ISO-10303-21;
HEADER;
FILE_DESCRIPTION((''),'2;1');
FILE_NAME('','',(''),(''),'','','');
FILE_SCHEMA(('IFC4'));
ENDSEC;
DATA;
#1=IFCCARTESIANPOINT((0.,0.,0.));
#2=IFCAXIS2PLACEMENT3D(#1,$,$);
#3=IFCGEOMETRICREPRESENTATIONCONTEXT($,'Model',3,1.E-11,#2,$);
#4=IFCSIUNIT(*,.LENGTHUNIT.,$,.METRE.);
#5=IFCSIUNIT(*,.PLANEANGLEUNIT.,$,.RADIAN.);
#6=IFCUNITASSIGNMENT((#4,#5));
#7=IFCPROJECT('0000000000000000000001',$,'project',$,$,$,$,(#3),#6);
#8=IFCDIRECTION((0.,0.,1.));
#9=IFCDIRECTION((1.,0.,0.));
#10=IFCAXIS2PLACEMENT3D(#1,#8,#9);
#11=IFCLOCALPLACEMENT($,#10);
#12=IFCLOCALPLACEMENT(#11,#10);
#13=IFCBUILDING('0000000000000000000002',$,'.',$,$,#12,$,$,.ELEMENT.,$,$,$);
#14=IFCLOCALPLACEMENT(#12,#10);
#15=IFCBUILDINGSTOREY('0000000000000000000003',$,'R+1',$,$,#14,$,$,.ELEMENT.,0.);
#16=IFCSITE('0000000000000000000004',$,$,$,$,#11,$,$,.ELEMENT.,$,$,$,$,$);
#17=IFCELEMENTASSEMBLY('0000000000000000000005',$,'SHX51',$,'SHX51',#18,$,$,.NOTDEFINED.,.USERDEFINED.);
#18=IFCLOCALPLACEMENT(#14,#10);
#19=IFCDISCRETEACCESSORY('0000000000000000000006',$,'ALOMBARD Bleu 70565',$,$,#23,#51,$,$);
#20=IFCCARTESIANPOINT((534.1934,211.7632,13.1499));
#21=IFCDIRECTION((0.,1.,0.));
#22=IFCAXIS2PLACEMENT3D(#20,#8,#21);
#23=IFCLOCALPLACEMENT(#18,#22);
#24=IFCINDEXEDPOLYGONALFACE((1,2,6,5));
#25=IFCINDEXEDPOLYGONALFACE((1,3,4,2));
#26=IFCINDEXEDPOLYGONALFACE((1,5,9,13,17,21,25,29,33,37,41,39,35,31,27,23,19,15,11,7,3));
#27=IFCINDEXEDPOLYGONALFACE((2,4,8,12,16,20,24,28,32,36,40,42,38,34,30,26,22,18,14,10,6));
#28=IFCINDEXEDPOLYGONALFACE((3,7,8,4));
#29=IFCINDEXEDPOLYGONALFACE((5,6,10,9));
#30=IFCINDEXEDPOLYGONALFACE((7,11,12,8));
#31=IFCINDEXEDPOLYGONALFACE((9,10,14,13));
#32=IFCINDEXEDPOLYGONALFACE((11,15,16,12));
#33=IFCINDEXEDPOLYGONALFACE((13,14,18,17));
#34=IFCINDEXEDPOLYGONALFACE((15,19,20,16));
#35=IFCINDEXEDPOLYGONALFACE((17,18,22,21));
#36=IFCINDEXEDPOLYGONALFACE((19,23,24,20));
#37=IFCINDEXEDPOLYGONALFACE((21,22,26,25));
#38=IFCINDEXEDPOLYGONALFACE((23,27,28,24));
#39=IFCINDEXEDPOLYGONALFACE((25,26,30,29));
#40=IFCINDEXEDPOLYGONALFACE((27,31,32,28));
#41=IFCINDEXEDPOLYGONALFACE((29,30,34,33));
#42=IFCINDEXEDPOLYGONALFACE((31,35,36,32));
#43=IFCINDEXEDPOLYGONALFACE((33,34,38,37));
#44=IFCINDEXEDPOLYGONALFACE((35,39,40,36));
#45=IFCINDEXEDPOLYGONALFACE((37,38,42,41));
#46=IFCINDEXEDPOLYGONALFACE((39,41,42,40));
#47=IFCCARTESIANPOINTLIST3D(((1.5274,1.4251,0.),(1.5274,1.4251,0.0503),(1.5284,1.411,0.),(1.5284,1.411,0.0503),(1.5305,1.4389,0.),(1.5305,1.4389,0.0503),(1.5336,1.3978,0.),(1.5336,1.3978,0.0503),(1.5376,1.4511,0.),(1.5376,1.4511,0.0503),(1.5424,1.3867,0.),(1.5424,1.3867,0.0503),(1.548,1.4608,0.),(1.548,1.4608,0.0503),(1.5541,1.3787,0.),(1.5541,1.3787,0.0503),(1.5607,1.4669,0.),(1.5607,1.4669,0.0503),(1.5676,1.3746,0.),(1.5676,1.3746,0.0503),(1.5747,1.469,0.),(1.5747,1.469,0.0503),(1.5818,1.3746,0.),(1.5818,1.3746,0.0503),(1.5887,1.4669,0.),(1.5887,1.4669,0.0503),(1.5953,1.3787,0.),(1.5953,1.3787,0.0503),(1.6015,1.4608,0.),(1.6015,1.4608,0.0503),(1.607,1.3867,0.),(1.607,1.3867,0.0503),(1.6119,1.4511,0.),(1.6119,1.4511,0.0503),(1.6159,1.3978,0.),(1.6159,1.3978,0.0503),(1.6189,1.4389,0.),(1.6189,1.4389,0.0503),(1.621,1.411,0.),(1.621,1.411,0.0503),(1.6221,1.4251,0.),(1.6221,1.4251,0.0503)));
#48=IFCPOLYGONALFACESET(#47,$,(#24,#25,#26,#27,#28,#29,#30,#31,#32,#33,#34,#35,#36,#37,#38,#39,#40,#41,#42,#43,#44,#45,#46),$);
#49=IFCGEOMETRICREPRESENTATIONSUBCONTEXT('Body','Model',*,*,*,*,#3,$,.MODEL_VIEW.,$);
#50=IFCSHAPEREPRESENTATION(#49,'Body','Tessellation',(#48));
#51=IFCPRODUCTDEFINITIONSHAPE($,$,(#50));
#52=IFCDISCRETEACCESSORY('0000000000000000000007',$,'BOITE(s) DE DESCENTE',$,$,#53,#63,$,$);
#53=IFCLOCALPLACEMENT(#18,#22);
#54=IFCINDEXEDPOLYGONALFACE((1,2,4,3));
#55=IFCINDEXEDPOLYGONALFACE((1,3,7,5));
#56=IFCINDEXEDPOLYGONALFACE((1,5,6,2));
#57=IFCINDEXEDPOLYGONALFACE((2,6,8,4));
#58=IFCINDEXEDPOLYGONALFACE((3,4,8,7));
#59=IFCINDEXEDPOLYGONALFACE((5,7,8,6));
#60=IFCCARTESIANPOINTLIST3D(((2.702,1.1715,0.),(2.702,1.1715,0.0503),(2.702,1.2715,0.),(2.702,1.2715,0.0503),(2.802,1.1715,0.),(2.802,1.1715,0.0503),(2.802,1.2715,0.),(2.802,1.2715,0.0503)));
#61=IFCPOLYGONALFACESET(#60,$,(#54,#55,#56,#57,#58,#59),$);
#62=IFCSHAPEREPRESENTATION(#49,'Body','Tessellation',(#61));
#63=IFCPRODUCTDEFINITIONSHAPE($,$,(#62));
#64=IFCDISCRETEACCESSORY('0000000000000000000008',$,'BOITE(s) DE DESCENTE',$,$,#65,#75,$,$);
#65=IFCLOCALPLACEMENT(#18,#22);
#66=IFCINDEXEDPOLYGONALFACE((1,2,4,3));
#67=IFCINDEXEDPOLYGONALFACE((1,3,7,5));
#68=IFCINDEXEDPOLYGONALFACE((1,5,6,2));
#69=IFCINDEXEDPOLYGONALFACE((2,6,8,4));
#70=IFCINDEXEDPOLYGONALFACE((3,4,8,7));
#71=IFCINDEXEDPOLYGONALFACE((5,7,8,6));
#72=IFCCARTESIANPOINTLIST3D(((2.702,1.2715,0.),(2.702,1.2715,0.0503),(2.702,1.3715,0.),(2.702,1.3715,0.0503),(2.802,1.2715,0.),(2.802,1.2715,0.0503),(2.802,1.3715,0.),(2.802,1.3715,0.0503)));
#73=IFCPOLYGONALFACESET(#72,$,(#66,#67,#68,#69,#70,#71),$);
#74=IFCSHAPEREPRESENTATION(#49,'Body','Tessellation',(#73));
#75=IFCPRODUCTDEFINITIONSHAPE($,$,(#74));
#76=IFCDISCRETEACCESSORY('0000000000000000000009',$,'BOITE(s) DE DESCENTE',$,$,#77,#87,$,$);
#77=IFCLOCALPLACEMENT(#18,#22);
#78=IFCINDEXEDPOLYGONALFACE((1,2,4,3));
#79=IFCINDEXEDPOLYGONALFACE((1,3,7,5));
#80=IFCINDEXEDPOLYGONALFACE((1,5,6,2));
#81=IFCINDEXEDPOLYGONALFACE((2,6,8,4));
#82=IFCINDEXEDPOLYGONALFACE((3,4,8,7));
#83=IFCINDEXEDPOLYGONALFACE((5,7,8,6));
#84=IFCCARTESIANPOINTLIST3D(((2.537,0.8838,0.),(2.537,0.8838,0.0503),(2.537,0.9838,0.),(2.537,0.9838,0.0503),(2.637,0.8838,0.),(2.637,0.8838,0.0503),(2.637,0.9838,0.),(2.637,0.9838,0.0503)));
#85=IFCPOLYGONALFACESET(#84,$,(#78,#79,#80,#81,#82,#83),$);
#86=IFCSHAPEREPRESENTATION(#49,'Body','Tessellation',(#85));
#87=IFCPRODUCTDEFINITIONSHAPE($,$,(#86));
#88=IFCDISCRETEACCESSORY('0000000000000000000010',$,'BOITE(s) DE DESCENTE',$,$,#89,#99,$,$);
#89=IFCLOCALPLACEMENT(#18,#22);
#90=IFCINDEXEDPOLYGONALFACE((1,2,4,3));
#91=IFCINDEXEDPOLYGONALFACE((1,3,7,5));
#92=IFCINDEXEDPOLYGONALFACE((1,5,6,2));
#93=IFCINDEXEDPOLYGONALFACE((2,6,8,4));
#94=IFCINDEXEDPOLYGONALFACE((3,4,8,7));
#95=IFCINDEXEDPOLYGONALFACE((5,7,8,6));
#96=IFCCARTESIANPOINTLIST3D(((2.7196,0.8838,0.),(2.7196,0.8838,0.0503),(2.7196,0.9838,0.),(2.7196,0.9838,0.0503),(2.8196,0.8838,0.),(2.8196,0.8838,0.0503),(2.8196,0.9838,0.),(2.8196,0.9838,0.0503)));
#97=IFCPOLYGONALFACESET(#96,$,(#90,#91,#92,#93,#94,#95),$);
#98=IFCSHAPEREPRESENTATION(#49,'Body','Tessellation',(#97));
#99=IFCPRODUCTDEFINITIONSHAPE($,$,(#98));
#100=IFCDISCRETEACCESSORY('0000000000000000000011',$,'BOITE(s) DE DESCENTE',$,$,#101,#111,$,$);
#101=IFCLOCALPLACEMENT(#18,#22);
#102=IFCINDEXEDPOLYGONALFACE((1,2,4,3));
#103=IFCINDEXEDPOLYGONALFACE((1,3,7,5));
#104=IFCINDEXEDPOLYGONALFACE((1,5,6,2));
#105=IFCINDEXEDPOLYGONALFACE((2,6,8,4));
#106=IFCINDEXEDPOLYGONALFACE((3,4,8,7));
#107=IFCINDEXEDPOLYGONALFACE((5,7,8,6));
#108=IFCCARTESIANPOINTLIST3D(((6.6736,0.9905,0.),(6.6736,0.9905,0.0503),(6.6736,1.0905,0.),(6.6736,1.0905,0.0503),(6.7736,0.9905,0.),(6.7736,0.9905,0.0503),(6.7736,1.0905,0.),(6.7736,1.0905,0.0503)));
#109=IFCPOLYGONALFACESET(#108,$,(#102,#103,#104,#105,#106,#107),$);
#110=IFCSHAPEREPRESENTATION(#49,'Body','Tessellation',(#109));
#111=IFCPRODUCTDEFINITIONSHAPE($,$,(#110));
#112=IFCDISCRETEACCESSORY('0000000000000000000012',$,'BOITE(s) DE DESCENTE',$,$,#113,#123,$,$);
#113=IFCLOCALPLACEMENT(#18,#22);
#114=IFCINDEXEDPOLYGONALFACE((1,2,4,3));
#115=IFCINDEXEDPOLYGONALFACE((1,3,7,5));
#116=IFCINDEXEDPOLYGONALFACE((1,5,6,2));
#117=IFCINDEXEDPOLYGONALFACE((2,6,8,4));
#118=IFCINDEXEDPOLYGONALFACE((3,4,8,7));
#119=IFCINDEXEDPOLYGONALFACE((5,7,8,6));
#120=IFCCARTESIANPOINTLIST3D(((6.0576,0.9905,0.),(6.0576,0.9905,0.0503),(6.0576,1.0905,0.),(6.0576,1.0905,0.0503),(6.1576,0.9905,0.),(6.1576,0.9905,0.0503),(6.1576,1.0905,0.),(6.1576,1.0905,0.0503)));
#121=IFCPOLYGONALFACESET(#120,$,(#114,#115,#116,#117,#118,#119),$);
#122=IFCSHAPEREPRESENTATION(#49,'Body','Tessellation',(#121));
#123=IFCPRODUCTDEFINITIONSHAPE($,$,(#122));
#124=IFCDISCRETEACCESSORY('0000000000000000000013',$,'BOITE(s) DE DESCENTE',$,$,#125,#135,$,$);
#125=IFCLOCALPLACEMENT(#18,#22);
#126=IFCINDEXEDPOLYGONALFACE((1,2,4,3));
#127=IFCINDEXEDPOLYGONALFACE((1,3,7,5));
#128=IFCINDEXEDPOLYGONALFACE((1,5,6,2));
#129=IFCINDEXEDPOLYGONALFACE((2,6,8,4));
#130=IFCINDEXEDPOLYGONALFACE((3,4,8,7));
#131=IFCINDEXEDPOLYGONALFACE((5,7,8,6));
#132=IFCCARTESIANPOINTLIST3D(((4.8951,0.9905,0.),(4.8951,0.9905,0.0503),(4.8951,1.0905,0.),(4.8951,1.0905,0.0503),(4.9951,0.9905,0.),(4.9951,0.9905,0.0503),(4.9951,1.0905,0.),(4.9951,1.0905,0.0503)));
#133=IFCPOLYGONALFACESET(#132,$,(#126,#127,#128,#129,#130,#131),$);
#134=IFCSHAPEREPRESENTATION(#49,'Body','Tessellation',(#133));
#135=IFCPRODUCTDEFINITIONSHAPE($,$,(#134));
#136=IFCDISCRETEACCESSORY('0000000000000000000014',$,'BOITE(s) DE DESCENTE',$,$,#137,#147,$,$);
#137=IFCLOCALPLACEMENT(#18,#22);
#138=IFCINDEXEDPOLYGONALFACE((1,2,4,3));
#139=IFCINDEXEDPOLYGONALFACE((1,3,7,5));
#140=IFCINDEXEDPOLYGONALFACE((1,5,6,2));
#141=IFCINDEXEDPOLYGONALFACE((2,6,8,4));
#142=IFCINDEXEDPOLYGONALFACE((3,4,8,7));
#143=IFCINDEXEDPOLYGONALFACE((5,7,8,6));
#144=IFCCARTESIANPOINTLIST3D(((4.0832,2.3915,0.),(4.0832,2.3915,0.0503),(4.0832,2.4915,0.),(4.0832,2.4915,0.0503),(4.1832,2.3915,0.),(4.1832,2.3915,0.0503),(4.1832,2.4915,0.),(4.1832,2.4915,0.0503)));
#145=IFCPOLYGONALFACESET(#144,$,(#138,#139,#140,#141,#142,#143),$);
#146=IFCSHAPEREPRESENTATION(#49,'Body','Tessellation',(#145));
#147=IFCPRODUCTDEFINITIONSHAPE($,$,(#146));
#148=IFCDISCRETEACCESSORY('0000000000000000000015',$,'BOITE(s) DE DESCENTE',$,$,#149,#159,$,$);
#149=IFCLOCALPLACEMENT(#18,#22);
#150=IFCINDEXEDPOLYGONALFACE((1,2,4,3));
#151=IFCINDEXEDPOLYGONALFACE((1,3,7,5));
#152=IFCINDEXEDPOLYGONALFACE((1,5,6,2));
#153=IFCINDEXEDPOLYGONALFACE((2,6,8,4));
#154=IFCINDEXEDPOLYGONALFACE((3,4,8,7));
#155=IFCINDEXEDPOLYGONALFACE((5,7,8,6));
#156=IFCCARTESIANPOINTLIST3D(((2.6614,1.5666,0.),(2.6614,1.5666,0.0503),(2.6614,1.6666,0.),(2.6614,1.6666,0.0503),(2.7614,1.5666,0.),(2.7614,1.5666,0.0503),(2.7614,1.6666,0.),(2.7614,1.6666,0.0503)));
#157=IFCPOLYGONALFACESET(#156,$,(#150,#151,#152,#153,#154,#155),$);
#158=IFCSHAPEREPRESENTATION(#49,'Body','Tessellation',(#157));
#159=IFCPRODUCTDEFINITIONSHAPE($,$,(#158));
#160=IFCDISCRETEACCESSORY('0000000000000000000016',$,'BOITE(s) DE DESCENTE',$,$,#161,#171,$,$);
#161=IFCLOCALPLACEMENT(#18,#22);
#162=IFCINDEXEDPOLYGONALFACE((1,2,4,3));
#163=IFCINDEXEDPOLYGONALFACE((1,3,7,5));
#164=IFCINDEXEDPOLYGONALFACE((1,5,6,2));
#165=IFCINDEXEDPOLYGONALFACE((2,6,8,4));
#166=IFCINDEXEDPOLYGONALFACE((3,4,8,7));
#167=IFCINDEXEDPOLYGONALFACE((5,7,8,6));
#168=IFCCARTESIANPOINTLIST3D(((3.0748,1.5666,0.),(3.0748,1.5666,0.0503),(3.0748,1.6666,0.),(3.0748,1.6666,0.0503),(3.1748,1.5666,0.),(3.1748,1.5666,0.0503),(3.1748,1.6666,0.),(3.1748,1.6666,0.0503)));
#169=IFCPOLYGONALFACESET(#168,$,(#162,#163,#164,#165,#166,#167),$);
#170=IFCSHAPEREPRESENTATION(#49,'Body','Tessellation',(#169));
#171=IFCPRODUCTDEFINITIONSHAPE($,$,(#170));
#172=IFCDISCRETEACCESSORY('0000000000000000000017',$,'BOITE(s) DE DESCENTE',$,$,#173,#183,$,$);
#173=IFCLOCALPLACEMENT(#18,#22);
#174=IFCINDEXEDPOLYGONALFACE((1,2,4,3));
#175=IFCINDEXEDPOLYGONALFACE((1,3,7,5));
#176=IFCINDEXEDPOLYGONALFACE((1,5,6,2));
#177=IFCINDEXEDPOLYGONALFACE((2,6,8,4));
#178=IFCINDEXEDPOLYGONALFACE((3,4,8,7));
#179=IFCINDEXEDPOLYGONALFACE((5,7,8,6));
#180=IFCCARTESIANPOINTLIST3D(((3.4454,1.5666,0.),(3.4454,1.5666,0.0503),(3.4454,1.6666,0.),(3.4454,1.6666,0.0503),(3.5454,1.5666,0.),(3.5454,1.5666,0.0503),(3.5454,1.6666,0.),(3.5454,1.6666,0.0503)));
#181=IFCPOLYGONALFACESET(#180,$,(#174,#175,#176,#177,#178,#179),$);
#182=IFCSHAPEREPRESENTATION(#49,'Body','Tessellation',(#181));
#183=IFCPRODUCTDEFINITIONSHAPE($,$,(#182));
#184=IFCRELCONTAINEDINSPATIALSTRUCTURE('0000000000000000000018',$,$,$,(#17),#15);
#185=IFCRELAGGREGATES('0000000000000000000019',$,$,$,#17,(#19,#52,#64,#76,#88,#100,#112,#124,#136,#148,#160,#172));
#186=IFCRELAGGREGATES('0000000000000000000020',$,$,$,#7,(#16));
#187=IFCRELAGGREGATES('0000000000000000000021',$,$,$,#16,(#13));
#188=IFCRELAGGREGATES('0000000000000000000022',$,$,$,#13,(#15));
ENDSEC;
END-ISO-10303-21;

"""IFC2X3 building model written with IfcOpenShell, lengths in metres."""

from ifc_helpers import new_model, si_unit, frame, frame_2d, origin, origin_with_axes, place, context, subcontext, project, spatial, polyline, circle, outline, extrude, element, aggregate, save


model = new_model("IFC2X3")

# Units and contexts
model_context = context("Model", 3, precision=1e-11, world=origin())
body_context = subcontext(model_context, "Body", "Model", "MODEL_VIEW")
ifc_project = project(units=[si_unit("LENGTHUNIT", "METRE"), si_unit("PLANEANGLEUNIT", "RADIAN")], contexts=[model_context])

# Site, building, storey
site_placement = place(None, origin_with_axes())
site = spatial("IfcSite", under=ifc_project, at=site_placement, CompositionType="ELEMENT")
building_placement = place(site_placement, origin_with_axes())
building = spatial("IfcBuilding", under=site, at=building_placement, Name=".", CompositionType="ELEMENT")
storey_placement = place(building_placement, origin_with_axes())
storey = spatial("IfcBuildingStorey", under=building, at=storey_placement, Name="R+1", CompositionType="ELEMENT", Elevation=0.0)

# Element assembly, discrete accessories
assembly_1_placement = place(storey_placement, origin_with_axes())
assembly_1 = element("IfcElementAssembly", 1, at=assembly_1_placement, inside=storey, Name="SHX51", ObjectType="SHX51", AssemblyPlace="NOTDEFINED", PredefinedType="USERDEFINED")
discrete_accessory_1_placement = place(assembly_1_placement, frame((534.1934, 211.7632, 13.1499), z_axis=(0.0, 0.0, 1.0), x_axis=(0.0, 1.0, 0.0)))
discrete_accessory_1 = element("IfcDiscreteAccessory", 2, at=discrete_accessory_1_placement, Name="ALOMBARD Bleu 70565", context=body_context, shape_type="SweptSolid", body=[
    extrude(circle(Radius=0.0475, at=frame_2d((1.4215, -1.5747), x_axis=(1.0, 0.0))), frame((0.0, 0.0, 0.0), z_axis=(0.0, 0.0, 1.0), x_axis=(0.0, 1.0, 0.0)), (0.0, 0.0, 1.0), 0.0503),
])
discrete_accessory_2_placement = place(assembly_1_placement, frame((534.1934, 211.7632, 13.1499), z_axis=(0.0, 0.0, 1.0), x_axis=(0.0, 1.0, 0.0)))
discrete_accessory_2 = element("IfcDiscreteAccessory", 3, at=discrete_accessory_2_placement, Name="BOITE(s) DE DESCENTE", context=body_context, shape_type="SweptSolid", body=[
    extrude(outline(polyline([(1.1715, -2.702), (1.1715, -2.802), (1.2715, -2.802), (1.2715, -2.702), (1.1715, -2.702)])), frame((0.0, 0.0, 0.0), z_axis=(0.0, 0.0, 1.0), x_axis=(0.0, 1.0, 0.0)), (0.0, 0.0, 1.0), 0.0503),
])
discrete_accessory_3_placement = place(assembly_1_placement, frame((534.1934, 211.7632, 13.1499), z_axis=(0.0, 0.0, 1.0), x_axis=(0.0, 1.0, 0.0)))
discrete_accessory_3 = element("IfcDiscreteAccessory", 4, at=discrete_accessory_3_placement, Name="BOITE(s) DE DESCENTE", context=body_context, shape_type="SweptSolid", body=[
    extrude(outline(polyline([(1.2715, -2.702), (1.2715, -2.802), (1.3715, -2.802), (1.3715, -2.702), (1.2715, -2.702)])), frame((0.0, 0.0, 0.0), z_axis=(0.0, 0.0, 1.0), x_axis=(0.0, 1.0, 0.0)), (0.0, 0.0, 1.0), 0.0503),
])
discrete_accessory_4_placement = place(assembly_1_placement, frame((534.1934, 211.7632, 13.1499), z_axis=(0.0, 0.0, 1.0), x_axis=(0.0, 1.0, 0.0)))
discrete_accessory_4 = element("IfcDiscreteAccessory", 5, at=discrete_accessory_4_placement, Name="BOITE(s) DE DESCENTE", context=body_context, shape_type="SweptSolid", body=[
    extrude(outline(polyline([(0.8838, -2.537), (0.8838, -2.637), (0.9838, -2.637), (0.9838, -2.537), (0.8838, -2.537)])), frame((0.0, 0.0, 0.0), z_axis=(0.0, 0.0, 1.0), x_axis=(0.0, 1.0, 0.0)), (0.0, 0.0, 1.0), 0.0503),
])
discrete_accessory_5_placement = place(assembly_1_placement, frame((534.1934, 211.7632, 13.1499), z_axis=(0.0, 0.0, 1.0), x_axis=(0.0, 1.0, 0.0)))
discrete_accessory_5 = element("IfcDiscreteAccessory", 6, at=discrete_accessory_5_placement, Name="BOITE(s) DE DESCENTE", context=body_context, shape_type="SweptSolid", body=[
    extrude(outline(polyline([(0.8838, -2.7196), (0.8838, -2.8196), (0.9838, -2.8196), (0.9838, -2.7196), (0.8838, -2.7196)])), frame((0.0, 0.0, 0.0), z_axis=(0.0, 0.0, 1.0), x_axis=(0.0, 1.0, 0.0)), (0.0, 0.0, 1.0), 0.0503),
])
discrete_accessory_6_placement = place(assembly_1_placement, frame((534.1934, 211.7632, 13.1499), z_axis=(0.0, 0.0, 1.0), x_axis=(0.0, 1.0, 0.0)))
discrete_accessory_6 = element("IfcDiscreteAccessory", 7, at=discrete_accessory_6_placement, Name="BOITE(s) DE DESCENTE", context=body_context, shape_type="SweptSolid", body=[
    extrude(outline(polyline([(0.9905, -6.6736), (0.9905, -6.7736), (1.0905, -6.7736), (1.0905, -6.6736), (0.9905, -6.6736)])), frame((0.0, 0.0, 0.0), z_axis=(0.0, 0.0, 1.0), x_axis=(0.0, 1.0, 0.0)), (0.0, 0.0, 1.0), 0.0503),
])
discrete_accessory_7_placement = place(assembly_1_placement, frame((534.1934, 211.7632, 13.1499), z_axis=(0.0, 0.0, 1.0), x_axis=(0.0, 1.0, 0.0)))
discrete_accessory_7 = element("IfcDiscreteAccessory", 8, at=discrete_accessory_7_placement, Name="BOITE(s) DE DESCENTE", context=body_context, shape_type="SweptSolid", body=[
    extrude(outline(polyline([(0.9905, -6.0576), (0.9905, -6.1576), (1.0905, -6.1576), (1.0905, -6.0576), (0.9905, -6.0576)])), frame((0.0, 0.0, 0.0), z_axis=(0.0, 0.0, 1.0), x_axis=(0.0, 1.0, 0.0)), (0.0, 0.0, 1.0), 0.0503),
])
discrete_accessory_8_placement = place(assembly_1_placement, frame((534.1934, 211.7632, 13.1499), z_axis=(0.0, 0.0, 1.0), x_axis=(0.0, 1.0, 0.0)))
discrete_accessory_8 = element("IfcDiscreteAccessory", 9, at=discrete_accessory_8_placement, Name="BOITE(s) DE DESCENTE", context=body_context, shape_type="SweptSolid", body=[
    extrude(outline(polyline([(0.9905, -4.8951), (0.9905, -4.9951), (1.0905, -4.9951), (1.0905, -4.8951), (0.9905, -4.8951)])), frame((0.0, 0.0, 0.0), z_axis=(0.0, 0.0, 1.0), x_axis=(0.0, 1.0, 0.0)), (0.0, 0.0, 1.0), 0.0503),
])
discrete_accessory_9_placement = place(assembly_1_placement, frame((534.1934, 211.7632, 13.1499), z_axis=(0.0, 0.0, 1.0), x_axis=(0.0, 1.0, 0.0)))
discrete_accessory_9 = element("IfcDiscreteAccessory", 10, at=discrete_accessory_9_placement, Name="BOITE(s) DE DESCENTE", context=body_context, shape_type="SweptSolid", body=[
    extrude(outline(polyline([(2.3915, -4.0832), (2.3915, -4.1832), (2.4915, -4.1832), (2.4915, -4.0832), (2.3915, -4.0832)])), frame((0.0, 0.0, 0.0), z_axis=(0.0, 0.0, 1.0), x_axis=(0.0, 1.0, 0.0)), (0.0, 0.0, 1.0), 0.0503),
])
discrete_accessory_10_placement = place(assembly_1_placement, frame((534.1934, 211.7632, 13.1499), z_axis=(0.0, 0.0, 1.0), x_axis=(0.0, 1.0, 0.0)))
discrete_accessory_10 = element("IfcDiscreteAccessory", 11, at=discrete_accessory_10_placement, Name="BOITE(s) DE DESCENTE", context=body_context, shape_type="SweptSolid", body=[
    extrude(outline(polyline([(1.5666, -2.6614), (1.5666, -2.7614), (1.6666, -2.7614), (1.6666, -2.6614), (1.5666, -2.6614)])), frame((0.0, 0.0, 0.0), z_axis=(0.0, 0.0, 1.0), x_axis=(0.0, 1.0, 0.0)), (0.0, 0.0, 1.0), 0.0503),
])
discrete_accessory_11_placement = place(assembly_1_placement, frame((534.1934, 211.7632, 13.1499), z_axis=(0.0, 0.0, 1.0), x_axis=(0.0, 1.0, 0.0)))
discrete_accessory_11 = element("IfcDiscreteAccessory", 12, at=discrete_accessory_11_placement, Name="BOITE(s) DE DESCENTE", context=body_context, shape_type="SweptSolid", body=[
    extrude(outline(polyline([(1.5666, -3.0748), (1.5666, -3.1748), (1.6666, -3.1748), (1.6666, -3.0748), (1.5666, -3.0748)])), frame((0.0, 0.0, 0.0), z_axis=(0.0, 0.0, 1.0), x_axis=(0.0, 1.0, 0.0)), (0.0, 0.0, 1.0), 0.0503),
])
discrete_accessory_12_placement = place(assembly_1_placement, frame((534.1934, 211.7632, 13.1499), z_axis=(0.0, 0.0, 1.0), x_axis=(0.0, 1.0, 0.0)))
discrete_accessory_12 = element("IfcDiscreteAccessory", 13, at=discrete_accessory_12_placement, Name="BOITE(s) DE DESCENTE", context=body_context, shape_type="SweptSolid", body=[
    extrude(outline(polyline([(1.5666, -3.4454), (1.5666, -3.5454), (1.6666, -3.5454), (1.6666, -3.4454), (1.5666, -3.4454)])), frame((0.0, 0.0, 0.0), z_axis=(0.0, 0.0, 1.0), x_axis=(0.0, 1.0, 0.0)), (0.0, 0.0, 1.0), 0.0503),
])
aggregate(assembly_1, [discrete_accessory_1, discrete_accessory_2, discrete_accessory_3, discrete_accessory_4, discrete_accessory_5, discrete_accessory_6, discrete_accessory_7, discrete_accessory_8, discrete_accessory_9, discrete_accessory_10, discrete_accessory_11, discrete_accessory_12])

save(model, "model.ifc")
